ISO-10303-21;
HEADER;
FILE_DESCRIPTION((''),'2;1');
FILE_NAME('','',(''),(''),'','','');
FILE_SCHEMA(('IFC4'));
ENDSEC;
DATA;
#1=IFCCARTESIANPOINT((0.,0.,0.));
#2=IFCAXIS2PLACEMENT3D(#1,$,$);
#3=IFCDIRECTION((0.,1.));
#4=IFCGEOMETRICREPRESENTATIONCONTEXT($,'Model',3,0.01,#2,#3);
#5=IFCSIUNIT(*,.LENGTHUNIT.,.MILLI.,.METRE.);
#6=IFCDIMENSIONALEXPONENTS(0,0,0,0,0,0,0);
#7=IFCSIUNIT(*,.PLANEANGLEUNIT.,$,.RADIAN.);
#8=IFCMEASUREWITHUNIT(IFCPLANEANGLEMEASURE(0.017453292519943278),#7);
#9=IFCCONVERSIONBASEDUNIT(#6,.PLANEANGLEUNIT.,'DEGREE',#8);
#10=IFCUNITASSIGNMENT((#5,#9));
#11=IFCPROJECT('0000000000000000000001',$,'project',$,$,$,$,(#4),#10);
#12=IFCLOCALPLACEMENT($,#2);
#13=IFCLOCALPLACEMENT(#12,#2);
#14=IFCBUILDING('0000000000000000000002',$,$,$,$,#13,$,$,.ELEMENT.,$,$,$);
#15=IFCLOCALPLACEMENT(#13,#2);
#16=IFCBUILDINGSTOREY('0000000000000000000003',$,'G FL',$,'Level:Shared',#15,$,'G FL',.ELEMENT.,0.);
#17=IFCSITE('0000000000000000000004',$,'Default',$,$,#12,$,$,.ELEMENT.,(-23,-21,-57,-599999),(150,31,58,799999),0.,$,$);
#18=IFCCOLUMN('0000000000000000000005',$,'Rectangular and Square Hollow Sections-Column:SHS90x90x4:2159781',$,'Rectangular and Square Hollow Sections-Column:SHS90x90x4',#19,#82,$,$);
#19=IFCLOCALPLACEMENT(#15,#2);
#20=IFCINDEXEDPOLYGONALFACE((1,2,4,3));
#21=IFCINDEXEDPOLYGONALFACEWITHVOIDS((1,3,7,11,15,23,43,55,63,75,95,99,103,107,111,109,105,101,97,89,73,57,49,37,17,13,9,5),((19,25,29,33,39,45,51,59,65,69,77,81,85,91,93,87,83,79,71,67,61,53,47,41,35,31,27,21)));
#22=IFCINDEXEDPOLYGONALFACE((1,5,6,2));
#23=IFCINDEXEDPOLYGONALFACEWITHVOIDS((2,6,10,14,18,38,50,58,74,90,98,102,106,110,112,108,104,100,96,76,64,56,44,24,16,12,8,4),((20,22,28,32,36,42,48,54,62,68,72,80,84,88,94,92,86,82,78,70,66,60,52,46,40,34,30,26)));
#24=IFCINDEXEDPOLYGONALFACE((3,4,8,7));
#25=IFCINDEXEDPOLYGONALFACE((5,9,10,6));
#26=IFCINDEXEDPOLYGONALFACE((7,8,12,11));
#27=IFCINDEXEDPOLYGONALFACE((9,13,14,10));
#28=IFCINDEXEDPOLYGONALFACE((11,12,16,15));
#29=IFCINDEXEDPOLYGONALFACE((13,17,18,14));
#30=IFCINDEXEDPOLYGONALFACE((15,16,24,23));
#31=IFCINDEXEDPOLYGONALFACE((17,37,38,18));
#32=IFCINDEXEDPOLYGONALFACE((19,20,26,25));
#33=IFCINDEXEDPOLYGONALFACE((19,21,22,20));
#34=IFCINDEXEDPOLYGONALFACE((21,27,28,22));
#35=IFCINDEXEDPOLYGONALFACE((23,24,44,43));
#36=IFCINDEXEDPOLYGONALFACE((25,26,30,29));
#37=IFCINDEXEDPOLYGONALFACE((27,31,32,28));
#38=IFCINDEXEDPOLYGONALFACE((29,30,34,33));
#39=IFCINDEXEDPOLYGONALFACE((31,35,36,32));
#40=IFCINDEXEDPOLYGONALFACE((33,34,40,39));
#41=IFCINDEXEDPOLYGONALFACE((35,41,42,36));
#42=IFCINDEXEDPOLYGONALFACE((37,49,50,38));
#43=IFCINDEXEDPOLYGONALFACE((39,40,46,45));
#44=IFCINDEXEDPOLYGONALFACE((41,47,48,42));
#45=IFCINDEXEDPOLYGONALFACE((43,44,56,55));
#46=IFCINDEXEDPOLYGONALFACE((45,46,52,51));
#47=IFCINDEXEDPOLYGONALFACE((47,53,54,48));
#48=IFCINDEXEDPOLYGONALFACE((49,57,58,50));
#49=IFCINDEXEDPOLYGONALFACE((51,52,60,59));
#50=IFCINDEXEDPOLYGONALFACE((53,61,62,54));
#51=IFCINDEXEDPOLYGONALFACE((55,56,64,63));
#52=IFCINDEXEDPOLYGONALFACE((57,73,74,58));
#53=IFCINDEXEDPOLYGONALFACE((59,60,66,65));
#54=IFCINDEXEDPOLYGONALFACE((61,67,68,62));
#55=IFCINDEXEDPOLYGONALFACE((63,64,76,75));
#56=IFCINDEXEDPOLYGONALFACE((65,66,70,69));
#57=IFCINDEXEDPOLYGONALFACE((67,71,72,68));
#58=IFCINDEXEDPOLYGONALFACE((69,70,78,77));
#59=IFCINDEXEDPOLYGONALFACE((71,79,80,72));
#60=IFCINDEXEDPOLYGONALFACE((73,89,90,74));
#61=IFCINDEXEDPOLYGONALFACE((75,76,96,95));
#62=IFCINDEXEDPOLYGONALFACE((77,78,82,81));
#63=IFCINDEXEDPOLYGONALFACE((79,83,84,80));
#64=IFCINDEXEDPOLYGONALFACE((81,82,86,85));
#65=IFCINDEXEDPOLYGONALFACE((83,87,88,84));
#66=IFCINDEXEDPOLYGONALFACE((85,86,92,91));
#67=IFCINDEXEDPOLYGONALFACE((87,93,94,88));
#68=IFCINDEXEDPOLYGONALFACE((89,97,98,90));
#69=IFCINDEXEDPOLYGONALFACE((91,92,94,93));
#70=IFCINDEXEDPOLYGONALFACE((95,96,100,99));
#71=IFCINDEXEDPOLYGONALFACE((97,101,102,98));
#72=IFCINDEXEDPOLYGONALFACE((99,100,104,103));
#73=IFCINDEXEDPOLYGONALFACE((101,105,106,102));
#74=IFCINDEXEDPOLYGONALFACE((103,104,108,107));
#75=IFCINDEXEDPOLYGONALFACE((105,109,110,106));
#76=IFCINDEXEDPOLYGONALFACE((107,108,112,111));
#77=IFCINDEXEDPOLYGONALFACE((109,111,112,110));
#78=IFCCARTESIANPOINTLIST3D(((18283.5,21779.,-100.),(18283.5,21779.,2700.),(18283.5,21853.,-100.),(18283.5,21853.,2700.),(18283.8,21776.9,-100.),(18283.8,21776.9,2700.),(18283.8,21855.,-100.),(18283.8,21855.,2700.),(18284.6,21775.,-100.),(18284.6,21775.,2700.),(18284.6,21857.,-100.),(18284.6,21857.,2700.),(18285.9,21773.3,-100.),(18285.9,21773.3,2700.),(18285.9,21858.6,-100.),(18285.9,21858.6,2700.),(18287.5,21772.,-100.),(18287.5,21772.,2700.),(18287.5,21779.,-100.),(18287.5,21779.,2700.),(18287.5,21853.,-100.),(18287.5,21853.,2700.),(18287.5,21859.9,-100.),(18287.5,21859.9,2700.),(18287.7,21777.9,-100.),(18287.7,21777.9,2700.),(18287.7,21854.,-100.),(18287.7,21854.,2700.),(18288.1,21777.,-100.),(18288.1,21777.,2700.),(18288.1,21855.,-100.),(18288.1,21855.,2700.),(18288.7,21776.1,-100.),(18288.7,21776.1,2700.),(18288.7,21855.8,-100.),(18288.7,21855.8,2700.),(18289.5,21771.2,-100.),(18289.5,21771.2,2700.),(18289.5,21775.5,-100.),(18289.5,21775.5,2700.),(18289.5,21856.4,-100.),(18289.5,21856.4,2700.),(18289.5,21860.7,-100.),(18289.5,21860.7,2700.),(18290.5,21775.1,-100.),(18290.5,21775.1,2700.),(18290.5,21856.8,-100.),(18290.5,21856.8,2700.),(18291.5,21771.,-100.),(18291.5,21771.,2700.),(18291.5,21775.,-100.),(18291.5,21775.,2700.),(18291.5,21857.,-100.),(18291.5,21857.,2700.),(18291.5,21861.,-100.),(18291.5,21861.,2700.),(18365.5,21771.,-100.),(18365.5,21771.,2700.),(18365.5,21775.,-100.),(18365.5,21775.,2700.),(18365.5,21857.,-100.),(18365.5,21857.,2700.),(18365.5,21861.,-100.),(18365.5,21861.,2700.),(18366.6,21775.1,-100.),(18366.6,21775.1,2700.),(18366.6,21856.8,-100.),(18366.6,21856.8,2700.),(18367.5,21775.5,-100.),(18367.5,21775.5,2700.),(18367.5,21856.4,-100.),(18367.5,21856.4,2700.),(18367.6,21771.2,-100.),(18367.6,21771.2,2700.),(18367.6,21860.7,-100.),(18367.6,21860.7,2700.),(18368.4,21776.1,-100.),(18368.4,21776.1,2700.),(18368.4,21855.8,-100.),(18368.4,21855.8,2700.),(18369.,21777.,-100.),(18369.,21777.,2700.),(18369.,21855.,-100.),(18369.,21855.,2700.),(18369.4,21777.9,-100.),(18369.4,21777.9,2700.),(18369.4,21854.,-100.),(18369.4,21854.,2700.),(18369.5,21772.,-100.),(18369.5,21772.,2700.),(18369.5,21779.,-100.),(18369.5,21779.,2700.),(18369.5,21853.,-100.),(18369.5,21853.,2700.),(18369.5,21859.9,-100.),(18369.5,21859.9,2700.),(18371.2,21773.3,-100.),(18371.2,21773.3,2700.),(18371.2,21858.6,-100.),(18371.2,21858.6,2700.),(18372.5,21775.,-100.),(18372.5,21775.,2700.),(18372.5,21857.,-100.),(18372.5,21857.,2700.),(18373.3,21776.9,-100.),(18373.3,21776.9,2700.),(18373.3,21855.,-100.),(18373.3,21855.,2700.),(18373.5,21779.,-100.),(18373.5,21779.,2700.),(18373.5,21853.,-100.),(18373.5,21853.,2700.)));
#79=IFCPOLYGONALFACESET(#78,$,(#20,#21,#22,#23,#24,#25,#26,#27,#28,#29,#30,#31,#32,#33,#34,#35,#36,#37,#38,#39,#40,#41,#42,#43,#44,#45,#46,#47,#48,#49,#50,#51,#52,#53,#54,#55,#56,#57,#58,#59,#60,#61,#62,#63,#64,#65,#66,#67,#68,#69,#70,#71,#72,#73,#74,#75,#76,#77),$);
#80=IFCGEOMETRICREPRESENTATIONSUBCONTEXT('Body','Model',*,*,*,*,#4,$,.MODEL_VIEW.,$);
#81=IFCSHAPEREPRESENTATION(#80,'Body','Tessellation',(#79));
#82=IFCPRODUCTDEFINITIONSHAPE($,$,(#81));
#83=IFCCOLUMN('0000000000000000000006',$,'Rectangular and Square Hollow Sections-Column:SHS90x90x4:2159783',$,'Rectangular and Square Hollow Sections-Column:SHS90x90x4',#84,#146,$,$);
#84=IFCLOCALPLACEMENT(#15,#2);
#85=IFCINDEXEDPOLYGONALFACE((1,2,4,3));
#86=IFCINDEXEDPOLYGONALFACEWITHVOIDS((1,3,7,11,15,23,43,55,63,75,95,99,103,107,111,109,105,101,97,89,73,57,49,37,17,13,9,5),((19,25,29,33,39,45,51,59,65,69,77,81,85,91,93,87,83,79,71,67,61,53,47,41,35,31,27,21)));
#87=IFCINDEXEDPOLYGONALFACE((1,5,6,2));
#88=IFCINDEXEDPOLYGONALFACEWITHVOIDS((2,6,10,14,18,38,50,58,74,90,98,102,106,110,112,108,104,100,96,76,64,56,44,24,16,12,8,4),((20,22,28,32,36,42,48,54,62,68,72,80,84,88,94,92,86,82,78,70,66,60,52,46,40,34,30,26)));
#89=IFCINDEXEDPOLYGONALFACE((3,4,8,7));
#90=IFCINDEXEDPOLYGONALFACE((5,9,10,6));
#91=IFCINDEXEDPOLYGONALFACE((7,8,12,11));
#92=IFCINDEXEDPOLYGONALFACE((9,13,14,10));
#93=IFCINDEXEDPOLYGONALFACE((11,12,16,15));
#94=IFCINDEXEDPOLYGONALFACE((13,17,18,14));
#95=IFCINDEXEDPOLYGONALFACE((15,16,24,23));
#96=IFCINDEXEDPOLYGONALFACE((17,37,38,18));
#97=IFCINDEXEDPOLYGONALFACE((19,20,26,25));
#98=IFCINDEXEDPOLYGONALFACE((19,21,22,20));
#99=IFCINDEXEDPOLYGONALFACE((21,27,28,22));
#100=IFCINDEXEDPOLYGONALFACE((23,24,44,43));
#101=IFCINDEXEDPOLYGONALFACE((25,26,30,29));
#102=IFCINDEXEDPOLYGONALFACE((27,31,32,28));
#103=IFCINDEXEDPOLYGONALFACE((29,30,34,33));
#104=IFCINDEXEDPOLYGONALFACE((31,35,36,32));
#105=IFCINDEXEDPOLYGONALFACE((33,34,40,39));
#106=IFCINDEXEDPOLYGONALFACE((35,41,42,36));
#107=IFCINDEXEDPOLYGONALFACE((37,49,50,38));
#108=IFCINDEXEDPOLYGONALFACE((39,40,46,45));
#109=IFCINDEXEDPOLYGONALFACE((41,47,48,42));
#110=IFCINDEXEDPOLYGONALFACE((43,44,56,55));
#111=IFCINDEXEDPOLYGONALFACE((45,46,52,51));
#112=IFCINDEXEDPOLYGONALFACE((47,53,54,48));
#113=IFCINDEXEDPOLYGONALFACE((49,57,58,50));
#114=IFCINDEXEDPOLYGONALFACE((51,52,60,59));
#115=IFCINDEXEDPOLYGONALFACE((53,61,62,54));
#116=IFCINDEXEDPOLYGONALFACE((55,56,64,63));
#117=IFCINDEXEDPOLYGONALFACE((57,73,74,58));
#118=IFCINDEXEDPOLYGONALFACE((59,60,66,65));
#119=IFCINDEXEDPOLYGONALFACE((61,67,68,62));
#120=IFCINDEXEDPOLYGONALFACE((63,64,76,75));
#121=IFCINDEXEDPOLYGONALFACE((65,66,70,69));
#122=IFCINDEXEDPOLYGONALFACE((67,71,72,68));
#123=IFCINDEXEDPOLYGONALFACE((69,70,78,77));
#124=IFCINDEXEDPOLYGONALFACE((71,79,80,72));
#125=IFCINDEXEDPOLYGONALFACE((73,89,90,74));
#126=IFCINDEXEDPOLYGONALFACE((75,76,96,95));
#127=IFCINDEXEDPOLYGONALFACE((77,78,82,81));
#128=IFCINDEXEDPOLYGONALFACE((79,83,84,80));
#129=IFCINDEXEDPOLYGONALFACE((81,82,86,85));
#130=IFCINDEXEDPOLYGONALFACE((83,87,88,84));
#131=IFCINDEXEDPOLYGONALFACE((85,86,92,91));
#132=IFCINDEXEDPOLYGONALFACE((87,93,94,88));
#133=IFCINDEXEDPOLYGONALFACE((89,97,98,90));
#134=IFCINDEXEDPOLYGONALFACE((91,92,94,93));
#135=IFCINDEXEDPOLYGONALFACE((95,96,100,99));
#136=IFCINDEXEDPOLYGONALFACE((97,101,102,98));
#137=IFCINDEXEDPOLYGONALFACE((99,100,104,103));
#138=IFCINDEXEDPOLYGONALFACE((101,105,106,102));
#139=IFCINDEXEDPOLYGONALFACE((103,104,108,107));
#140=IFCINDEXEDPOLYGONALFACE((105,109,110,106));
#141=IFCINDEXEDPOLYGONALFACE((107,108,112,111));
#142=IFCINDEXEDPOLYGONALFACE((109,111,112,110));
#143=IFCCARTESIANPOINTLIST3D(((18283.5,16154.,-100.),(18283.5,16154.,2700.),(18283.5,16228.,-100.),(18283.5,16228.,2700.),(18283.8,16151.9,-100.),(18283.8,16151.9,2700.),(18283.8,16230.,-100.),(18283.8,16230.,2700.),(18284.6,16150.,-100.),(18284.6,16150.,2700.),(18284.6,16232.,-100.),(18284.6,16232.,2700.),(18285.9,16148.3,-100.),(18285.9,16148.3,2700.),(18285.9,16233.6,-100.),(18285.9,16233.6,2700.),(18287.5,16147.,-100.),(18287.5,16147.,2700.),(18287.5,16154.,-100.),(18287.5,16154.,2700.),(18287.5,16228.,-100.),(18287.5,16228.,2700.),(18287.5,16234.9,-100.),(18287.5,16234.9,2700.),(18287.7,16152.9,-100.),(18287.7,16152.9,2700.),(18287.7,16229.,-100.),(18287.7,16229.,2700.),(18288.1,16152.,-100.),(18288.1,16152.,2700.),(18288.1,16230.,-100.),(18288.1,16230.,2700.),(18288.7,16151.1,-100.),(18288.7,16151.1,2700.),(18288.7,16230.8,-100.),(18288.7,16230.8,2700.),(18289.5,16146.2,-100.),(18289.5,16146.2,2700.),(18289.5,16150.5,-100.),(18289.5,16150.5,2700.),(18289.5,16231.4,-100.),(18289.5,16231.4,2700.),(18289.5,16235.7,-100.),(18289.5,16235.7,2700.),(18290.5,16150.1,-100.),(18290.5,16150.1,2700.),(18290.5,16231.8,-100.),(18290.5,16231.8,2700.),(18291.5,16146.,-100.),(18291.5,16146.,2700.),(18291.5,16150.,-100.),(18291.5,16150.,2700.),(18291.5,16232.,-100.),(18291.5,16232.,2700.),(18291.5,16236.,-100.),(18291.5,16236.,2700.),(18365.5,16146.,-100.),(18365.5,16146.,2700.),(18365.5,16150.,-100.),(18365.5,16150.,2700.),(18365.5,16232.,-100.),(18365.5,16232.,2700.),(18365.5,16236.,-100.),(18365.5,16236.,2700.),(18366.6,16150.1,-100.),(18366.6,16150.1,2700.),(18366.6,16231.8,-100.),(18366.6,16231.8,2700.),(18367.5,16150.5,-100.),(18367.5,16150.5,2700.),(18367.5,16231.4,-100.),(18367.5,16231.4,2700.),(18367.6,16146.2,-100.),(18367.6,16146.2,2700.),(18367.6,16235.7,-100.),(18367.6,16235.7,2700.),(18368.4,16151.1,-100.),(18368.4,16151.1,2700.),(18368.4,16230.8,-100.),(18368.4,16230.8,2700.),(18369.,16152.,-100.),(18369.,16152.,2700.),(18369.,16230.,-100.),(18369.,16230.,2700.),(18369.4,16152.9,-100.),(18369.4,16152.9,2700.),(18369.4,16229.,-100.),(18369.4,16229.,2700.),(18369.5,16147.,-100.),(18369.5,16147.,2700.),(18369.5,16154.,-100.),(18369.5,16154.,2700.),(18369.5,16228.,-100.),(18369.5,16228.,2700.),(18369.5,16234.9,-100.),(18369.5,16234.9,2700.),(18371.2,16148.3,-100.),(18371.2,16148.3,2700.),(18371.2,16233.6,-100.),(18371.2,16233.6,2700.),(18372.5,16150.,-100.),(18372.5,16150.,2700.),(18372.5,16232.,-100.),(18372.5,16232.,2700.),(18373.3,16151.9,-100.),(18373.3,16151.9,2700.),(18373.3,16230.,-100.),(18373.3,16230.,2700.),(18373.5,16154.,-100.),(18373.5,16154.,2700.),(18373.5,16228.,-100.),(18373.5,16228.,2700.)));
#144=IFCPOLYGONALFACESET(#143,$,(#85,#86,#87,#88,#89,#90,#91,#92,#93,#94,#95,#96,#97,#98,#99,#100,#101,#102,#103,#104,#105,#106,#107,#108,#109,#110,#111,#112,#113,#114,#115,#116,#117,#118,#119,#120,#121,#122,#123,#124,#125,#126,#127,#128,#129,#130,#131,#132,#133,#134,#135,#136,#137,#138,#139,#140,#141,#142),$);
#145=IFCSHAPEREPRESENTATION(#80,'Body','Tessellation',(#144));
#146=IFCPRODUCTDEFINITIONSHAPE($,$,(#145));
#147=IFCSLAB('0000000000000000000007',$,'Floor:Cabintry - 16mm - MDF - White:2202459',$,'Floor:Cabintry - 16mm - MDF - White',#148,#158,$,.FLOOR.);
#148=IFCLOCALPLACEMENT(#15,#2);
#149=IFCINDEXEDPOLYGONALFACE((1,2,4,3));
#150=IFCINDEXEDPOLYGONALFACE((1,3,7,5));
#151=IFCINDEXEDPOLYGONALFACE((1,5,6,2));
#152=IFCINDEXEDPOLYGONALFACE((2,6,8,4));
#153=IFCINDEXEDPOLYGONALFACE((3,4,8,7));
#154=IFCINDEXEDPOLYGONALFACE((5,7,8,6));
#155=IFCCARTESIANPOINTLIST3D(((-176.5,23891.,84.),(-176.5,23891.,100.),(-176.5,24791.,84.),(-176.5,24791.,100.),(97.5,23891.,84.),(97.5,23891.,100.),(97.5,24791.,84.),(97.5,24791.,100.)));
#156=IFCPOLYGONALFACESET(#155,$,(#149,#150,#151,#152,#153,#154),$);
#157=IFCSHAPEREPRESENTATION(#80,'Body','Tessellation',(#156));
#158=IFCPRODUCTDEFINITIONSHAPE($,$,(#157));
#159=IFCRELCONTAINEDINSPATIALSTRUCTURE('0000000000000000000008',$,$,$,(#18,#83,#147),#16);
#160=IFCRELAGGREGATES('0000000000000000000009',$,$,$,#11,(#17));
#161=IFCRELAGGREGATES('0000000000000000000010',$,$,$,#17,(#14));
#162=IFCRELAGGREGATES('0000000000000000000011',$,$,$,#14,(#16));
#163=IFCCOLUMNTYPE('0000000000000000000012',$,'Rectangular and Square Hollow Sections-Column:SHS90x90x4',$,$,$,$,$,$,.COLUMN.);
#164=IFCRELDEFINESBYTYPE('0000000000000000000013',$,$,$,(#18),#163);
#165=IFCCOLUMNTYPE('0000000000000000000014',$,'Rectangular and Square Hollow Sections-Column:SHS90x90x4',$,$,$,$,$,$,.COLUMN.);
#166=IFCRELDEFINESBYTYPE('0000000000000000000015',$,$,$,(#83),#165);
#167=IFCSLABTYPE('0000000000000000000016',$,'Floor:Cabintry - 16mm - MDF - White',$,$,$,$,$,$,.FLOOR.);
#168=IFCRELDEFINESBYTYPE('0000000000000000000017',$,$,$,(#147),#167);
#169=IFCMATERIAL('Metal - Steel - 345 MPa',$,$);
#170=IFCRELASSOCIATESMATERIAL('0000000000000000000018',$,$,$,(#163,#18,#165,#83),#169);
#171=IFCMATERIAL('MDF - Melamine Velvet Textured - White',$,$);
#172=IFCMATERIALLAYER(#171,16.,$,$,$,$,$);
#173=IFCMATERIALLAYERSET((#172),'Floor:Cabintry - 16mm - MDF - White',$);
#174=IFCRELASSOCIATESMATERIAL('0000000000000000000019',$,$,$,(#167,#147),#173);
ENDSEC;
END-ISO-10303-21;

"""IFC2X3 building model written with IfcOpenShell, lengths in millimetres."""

from ifc_helpers import new_model, entity, si_unit, converted_unit, direction, frame, frame_2d, origin, origin_2d_with_axis, place, context, subcontext, project, spatial, polyline, circle_curve, parameter, trimmed, segment, composite_curve, rectangle, outline, extrude, source, transform, mapped, material, layer, layer_set, layer_usage, type_object, type_shapes, element, save


model = new_model("IFC2X3")

# Units and contexts
model_context = context("Model", 3, precision=0.01, world=origin(), true_north=direction((0.0, 1.0)))
body_context = subcontext(model_context, "Body", "Model", "MODEL_VIEW")
ifc_project = project(units=[si_unit("LENGTHUNIT", "METRE", prefix="MILLI"), converted_unit("PLANEANGLEUNIT", "DEGREE", entity("IfcPlaneAngleMeasure", 0.017453292519943278), si_unit("PLANEANGLEUNIT", "RADIAN"), dimensions=[0, 0, 0, 0, 0, 0, 0])], contexts=[model_context])

# Site, building, storey
site_placement = place(None, origin())
site = spatial("IfcSite", under=ifc_project, at=site_placement, Name="Default", CompositionType="ELEMENT", RefLatitude=(-23, -21, -57, -599999), RefLongitude=(150, 31, 58, 799999), RefElevation=0.0)
building_placement = place(site_placement, origin())
building = spatial("IfcBuilding", under=site, at=building_placement, CompositionType="ELEMENT")
storey_placement = place(building_placement, origin())
storey = spatial("IfcBuildingStorey", under=building, at=storey_placement, Name="G FL", ObjectType="Level:Shared", LongName="G FL", CompositionType="ELEMENT", Elevation=0.0)

# Columns
ifc_material_1 = material(Name="Metal - Steel - 345 MPa")
column_type_1 = type_object("IfcColumnType", Name="Rectangular and Square Hollow Sections-Column:SHS90x90x4", PredefinedType="COLUMN", material=ifc_material_1)
shared_shape_1 = source(origin(), body_context, "Body", "SweptSolid", [
    extrude(outline(composite_curve([segment(trimmed(circle_curve(frame_2d((37.0, -37.0), x_axis=(1.0, 0.0)), 8.0), [parameter(270.0)], [parameter(0.0)], True, "PARAMETER"), True, "CONTINUOUS"), segment(polyline([(45.0, -37.0), (45.0, 37.0)]), True, "CONTINUOUS"), segment(trimmed(circle_curve(frame_2d((37.0, 37.0), x_axis=(1.0, 0.0)), 8.0), [parameter(0.0)], [parameter(90.0)], True, "PARAMETER"), True, "CONTINUOUS"), segment(polyline([(37.0, 45.0), (-37.0, 45.0)]), True, "CONTINUOUS"), segment(trimmed(circle_curve(frame_2d((-37.0, 37.0), x_axis=(1.0, 0.0)), 8.0), [parameter(90.0)], [parameter(180.0)], True, "PARAMETER"), True, "CONTINUOUS"), segment(polyline([(-45.0, 37.0), (-45.0, -37.0)]), True, "CONTINUOUS"), segment(trimmed(circle_curve(frame_2d((-37.0, -37.0), x_axis=(1.0, 0.0)), 8.0), [parameter(180.0)], [parameter(270.0)], True, "PARAMETER"), True, "CONTINUOUS"), segment(polyline([(-37.0, -45.0), (37.0, -45.0)]), True, "CONTINUOUS")], self_intersect=False), holes=[composite_curve([segment(polyline([(37.0, -41.0), (-37.0, -41.0)]), True, "CONTINUOUS"), segment(trimmed(circle_curve(frame_2d((-37.0, -37.0), x_axis=(1.0, 0.0)), 4.0), [parameter(180.0)], [parameter(270.0)], True, "PARAMETER"), False, "CONTINUOUS"), segment(polyline([(-41.0, -37.0), (-41.0, 37.0)]), True, "CONTINUOUS"), segment(trimmed(circle_curve(frame_2d((-37.0, 37.0), x_axis=(1.0, 0.0)), 4.0), [parameter(90.0)], [parameter(180.0)], True, "PARAMETER"), False, "CONTINUOUS"), segment(polyline([(-37.0, 41.0), (37.0, 41.0)]), True, "CONTINUOUS"), segment(trimmed(circle_curve(frame_2d((37.0, 37.0), x_axis=(1.0, 0.0)), 4.0), [parameter(0.0)], [parameter(90.0)], True, "PARAMETER"), False, "CONTINUOUS"), segment(polyline([(41.0, 37.0), (41.0, -37.0)]), True, "CONTINUOUS"), segment(trimmed(circle_curve(frame_2d((37.0, -37.0), x_axis=(1.0, 0.0)), 4.0), [parameter(270.0)], [parameter(0.0)], True, "PARAMETER"), False, "CONTINUOUS")], self_intersect=False)]), frame((18328.5, 21816.0, -100.0)), (0.0, 0.0, 1.0), 2800.0),
])
type_shapes(column_type_1, [shared_shape_1])
column_1_placement = place(storey_placement, origin())
element("IfcColumn", 1, at=column_1_placement, inside=storey, type_object=column_type_1, material=ifc_material_1, Name="Rectangular and Square Hollow Sections-Column:SHS90x90x4:2159781", ObjectType="Rectangular and Square Hollow Sections-Column:SHS90x90x4", context=body_context, shape_type="MappedRepresentation", body=[
    mapped(shared_shape_1, transform((0.0, 0.0, 0.0), scale=1.0)),
])
column_type_2 = type_object("IfcColumnType", Name="Rectangular and Square Hollow Sections-Column:SHS90x90x4", PredefinedType="COLUMN", material=ifc_material_1)
shared_shape_2 = source(origin(), body_context, "Body", "SweptSolid", [
    extrude(outline(composite_curve([segment(trimmed(circle_curve(frame_2d((37.0, -37.0), x_axis=(1.0, 0.0)), 8.0), [parameter(270.0)], [parameter(0.0)], True, "PARAMETER"), True, "CONTINUOUS"), segment(polyline([(45.0, -37.0), (45.0, 37.0)]), True, "CONTINUOUS"), segment(trimmed(circle_curve(frame_2d((37.0, 37.0), x_axis=(1.0, 0.0)), 8.0), [parameter(0.0)], [parameter(90.0)], True, "PARAMETER"), True, "CONTINUOUS"), segment(polyline([(37.0, 45.0), (-37.0, 45.0)]), True, "CONTINUOUS"), segment(trimmed(circle_curve(frame_2d((-37.0, 37.0), x_axis=(1.0, 0.0)), 8.0), [parameter(90.0)], [parameter(180.0)], True, "PARAMETER"), True, "CONTINUOUS"), segment(polyline([(-45.0, 37.0), (-45.0, -37.0)]), True, "CONTINUOUS"), segment(trimmed(circle_curve(frame_2d((-37.0, -37.0), x_axis=(1.0, 0.0)), 8.0), [parameter(180.0)], [parameter(270.0)], True, "PARAMETER"), True, "CONTINUOUS"), segment(polyline([(-37.0, -45.0), (37.0, -45.0)]), True, "CONTINUOUS")], self_intersect=False), holes=[composite_curve([segment(polyline([(37.0, -41.0), (-37.0, -41.0)]), True, "CONTINUOUS"), segment(trimmed(circle_curve(frame_2d((-37.0, -37.0), x_axis=(1.0, 0.0)), 4.0), [parameter(180.0)], [parameter(270.0)], True, "PARAMETER"), False, "CONTINUOUS"), segment(polyline([(-41.0, -37.0), (-41.0, 37.0)]), True, "CONTINUOUS"), segment(trimmed(circle_curve(frame_2d((-37.0, 37.0), x_axis=(1.0, 0.0)), 4.0), [parameter(90.0)], [parameter(180.0)], True, "PARAMETER"), False, "CONTINUOUS"), segment(polyline([(-37.0, 41.0), (37.0, 41.0)]), True, "CONTINUOUS"), segment(trimmed(circle_curve(frame_2d((37.0, 37.0), x_axis=(1.0, 0.0)), 4.0), [parameter(0.0)], [parameter(90.0)], True, "PARAMETER"), False, "CONTINUOUS"), segment(polyline([(41.0, 37.0), (41.0, -37.0)]), True, "CONTINUOUS"), segment(trimmed(circle_curve(frame_2d((37.0, -37.0), x_axis=(1.0, 0.0)), 4.0), [parameter(270.0)], [parameter(0.0)], True, "PARAMETER"), False, "CONTINUOUS")], self_intersect=False)]), frame((18328.5, 16191.0, -100.0)), (0.0, 0.0, 1.0), 2800.0),
])
type_shapes(column_type_2, [shared_shape_2])
column_2_placement = place(storey_placement, origin())
element("IfcColumn", 2, at=column_2_placement, inside=storey, type_object=column_type_2, material=ifc_material_1, Name="Rectangular and Square Hollow Sections-Column:SHS90x90x4:2159783", ObjectType="Rectangular and Square Hollow Sections-Column:SHS90x90x4", context=body_context, shape_type="MappedRepresentation", body=[
    mapped(shared_shape_2, transform((0.0, 0.0, 0.0), scale=1.0)),
])

# Slab
ifc_material_2 = material(Name="MDF - Melamine Velvet Textured - White")
ifc_layer_1 = layer(ifc_material_2, 16.0)
ifc_layer_set_1 = layer_set([ifc_layer_1], Name="Floor:Cabintry - 16mm - MDF - White")
ifc_layer_usage_1 = layer_usage(ifc_layer_set_1, "AXIS3", "POSITIVE", 0.0)
slab_type_1 = type_object("IfcSlabType", Name="Floor:Cabintry - 16mm - MDF - White", PredefinedType="FLOOR", material=ifc_layer_set_1)
slab_1_placement = place(storey_placement, origin())
element("IfcSlab", 3, at=slab_1_placement, inside=storey, type_object=slab_type_1, material=ifc_layer_usage_1, Name="Floor:Cabintry - 16mm - MDF - White:2202459", ObjectType="Floor:Cabintry - 16mm - MDF - White", PredefinedType="FLOOR", context=body_context, shape_type="SweptSolid", body=[
    extrude(rectangle(XDim=900.0, YDim=274.0, at=origin_2d_with_axis()), frame((-39.5, 24341.0, 100.0), z_axis=(0.0, 0.0, -1.0), x_axis=(0.0, 1.0, 0.0)), (0.0, 0.0, 1.0), 16.0),
])

save(model, "model.ifc")
